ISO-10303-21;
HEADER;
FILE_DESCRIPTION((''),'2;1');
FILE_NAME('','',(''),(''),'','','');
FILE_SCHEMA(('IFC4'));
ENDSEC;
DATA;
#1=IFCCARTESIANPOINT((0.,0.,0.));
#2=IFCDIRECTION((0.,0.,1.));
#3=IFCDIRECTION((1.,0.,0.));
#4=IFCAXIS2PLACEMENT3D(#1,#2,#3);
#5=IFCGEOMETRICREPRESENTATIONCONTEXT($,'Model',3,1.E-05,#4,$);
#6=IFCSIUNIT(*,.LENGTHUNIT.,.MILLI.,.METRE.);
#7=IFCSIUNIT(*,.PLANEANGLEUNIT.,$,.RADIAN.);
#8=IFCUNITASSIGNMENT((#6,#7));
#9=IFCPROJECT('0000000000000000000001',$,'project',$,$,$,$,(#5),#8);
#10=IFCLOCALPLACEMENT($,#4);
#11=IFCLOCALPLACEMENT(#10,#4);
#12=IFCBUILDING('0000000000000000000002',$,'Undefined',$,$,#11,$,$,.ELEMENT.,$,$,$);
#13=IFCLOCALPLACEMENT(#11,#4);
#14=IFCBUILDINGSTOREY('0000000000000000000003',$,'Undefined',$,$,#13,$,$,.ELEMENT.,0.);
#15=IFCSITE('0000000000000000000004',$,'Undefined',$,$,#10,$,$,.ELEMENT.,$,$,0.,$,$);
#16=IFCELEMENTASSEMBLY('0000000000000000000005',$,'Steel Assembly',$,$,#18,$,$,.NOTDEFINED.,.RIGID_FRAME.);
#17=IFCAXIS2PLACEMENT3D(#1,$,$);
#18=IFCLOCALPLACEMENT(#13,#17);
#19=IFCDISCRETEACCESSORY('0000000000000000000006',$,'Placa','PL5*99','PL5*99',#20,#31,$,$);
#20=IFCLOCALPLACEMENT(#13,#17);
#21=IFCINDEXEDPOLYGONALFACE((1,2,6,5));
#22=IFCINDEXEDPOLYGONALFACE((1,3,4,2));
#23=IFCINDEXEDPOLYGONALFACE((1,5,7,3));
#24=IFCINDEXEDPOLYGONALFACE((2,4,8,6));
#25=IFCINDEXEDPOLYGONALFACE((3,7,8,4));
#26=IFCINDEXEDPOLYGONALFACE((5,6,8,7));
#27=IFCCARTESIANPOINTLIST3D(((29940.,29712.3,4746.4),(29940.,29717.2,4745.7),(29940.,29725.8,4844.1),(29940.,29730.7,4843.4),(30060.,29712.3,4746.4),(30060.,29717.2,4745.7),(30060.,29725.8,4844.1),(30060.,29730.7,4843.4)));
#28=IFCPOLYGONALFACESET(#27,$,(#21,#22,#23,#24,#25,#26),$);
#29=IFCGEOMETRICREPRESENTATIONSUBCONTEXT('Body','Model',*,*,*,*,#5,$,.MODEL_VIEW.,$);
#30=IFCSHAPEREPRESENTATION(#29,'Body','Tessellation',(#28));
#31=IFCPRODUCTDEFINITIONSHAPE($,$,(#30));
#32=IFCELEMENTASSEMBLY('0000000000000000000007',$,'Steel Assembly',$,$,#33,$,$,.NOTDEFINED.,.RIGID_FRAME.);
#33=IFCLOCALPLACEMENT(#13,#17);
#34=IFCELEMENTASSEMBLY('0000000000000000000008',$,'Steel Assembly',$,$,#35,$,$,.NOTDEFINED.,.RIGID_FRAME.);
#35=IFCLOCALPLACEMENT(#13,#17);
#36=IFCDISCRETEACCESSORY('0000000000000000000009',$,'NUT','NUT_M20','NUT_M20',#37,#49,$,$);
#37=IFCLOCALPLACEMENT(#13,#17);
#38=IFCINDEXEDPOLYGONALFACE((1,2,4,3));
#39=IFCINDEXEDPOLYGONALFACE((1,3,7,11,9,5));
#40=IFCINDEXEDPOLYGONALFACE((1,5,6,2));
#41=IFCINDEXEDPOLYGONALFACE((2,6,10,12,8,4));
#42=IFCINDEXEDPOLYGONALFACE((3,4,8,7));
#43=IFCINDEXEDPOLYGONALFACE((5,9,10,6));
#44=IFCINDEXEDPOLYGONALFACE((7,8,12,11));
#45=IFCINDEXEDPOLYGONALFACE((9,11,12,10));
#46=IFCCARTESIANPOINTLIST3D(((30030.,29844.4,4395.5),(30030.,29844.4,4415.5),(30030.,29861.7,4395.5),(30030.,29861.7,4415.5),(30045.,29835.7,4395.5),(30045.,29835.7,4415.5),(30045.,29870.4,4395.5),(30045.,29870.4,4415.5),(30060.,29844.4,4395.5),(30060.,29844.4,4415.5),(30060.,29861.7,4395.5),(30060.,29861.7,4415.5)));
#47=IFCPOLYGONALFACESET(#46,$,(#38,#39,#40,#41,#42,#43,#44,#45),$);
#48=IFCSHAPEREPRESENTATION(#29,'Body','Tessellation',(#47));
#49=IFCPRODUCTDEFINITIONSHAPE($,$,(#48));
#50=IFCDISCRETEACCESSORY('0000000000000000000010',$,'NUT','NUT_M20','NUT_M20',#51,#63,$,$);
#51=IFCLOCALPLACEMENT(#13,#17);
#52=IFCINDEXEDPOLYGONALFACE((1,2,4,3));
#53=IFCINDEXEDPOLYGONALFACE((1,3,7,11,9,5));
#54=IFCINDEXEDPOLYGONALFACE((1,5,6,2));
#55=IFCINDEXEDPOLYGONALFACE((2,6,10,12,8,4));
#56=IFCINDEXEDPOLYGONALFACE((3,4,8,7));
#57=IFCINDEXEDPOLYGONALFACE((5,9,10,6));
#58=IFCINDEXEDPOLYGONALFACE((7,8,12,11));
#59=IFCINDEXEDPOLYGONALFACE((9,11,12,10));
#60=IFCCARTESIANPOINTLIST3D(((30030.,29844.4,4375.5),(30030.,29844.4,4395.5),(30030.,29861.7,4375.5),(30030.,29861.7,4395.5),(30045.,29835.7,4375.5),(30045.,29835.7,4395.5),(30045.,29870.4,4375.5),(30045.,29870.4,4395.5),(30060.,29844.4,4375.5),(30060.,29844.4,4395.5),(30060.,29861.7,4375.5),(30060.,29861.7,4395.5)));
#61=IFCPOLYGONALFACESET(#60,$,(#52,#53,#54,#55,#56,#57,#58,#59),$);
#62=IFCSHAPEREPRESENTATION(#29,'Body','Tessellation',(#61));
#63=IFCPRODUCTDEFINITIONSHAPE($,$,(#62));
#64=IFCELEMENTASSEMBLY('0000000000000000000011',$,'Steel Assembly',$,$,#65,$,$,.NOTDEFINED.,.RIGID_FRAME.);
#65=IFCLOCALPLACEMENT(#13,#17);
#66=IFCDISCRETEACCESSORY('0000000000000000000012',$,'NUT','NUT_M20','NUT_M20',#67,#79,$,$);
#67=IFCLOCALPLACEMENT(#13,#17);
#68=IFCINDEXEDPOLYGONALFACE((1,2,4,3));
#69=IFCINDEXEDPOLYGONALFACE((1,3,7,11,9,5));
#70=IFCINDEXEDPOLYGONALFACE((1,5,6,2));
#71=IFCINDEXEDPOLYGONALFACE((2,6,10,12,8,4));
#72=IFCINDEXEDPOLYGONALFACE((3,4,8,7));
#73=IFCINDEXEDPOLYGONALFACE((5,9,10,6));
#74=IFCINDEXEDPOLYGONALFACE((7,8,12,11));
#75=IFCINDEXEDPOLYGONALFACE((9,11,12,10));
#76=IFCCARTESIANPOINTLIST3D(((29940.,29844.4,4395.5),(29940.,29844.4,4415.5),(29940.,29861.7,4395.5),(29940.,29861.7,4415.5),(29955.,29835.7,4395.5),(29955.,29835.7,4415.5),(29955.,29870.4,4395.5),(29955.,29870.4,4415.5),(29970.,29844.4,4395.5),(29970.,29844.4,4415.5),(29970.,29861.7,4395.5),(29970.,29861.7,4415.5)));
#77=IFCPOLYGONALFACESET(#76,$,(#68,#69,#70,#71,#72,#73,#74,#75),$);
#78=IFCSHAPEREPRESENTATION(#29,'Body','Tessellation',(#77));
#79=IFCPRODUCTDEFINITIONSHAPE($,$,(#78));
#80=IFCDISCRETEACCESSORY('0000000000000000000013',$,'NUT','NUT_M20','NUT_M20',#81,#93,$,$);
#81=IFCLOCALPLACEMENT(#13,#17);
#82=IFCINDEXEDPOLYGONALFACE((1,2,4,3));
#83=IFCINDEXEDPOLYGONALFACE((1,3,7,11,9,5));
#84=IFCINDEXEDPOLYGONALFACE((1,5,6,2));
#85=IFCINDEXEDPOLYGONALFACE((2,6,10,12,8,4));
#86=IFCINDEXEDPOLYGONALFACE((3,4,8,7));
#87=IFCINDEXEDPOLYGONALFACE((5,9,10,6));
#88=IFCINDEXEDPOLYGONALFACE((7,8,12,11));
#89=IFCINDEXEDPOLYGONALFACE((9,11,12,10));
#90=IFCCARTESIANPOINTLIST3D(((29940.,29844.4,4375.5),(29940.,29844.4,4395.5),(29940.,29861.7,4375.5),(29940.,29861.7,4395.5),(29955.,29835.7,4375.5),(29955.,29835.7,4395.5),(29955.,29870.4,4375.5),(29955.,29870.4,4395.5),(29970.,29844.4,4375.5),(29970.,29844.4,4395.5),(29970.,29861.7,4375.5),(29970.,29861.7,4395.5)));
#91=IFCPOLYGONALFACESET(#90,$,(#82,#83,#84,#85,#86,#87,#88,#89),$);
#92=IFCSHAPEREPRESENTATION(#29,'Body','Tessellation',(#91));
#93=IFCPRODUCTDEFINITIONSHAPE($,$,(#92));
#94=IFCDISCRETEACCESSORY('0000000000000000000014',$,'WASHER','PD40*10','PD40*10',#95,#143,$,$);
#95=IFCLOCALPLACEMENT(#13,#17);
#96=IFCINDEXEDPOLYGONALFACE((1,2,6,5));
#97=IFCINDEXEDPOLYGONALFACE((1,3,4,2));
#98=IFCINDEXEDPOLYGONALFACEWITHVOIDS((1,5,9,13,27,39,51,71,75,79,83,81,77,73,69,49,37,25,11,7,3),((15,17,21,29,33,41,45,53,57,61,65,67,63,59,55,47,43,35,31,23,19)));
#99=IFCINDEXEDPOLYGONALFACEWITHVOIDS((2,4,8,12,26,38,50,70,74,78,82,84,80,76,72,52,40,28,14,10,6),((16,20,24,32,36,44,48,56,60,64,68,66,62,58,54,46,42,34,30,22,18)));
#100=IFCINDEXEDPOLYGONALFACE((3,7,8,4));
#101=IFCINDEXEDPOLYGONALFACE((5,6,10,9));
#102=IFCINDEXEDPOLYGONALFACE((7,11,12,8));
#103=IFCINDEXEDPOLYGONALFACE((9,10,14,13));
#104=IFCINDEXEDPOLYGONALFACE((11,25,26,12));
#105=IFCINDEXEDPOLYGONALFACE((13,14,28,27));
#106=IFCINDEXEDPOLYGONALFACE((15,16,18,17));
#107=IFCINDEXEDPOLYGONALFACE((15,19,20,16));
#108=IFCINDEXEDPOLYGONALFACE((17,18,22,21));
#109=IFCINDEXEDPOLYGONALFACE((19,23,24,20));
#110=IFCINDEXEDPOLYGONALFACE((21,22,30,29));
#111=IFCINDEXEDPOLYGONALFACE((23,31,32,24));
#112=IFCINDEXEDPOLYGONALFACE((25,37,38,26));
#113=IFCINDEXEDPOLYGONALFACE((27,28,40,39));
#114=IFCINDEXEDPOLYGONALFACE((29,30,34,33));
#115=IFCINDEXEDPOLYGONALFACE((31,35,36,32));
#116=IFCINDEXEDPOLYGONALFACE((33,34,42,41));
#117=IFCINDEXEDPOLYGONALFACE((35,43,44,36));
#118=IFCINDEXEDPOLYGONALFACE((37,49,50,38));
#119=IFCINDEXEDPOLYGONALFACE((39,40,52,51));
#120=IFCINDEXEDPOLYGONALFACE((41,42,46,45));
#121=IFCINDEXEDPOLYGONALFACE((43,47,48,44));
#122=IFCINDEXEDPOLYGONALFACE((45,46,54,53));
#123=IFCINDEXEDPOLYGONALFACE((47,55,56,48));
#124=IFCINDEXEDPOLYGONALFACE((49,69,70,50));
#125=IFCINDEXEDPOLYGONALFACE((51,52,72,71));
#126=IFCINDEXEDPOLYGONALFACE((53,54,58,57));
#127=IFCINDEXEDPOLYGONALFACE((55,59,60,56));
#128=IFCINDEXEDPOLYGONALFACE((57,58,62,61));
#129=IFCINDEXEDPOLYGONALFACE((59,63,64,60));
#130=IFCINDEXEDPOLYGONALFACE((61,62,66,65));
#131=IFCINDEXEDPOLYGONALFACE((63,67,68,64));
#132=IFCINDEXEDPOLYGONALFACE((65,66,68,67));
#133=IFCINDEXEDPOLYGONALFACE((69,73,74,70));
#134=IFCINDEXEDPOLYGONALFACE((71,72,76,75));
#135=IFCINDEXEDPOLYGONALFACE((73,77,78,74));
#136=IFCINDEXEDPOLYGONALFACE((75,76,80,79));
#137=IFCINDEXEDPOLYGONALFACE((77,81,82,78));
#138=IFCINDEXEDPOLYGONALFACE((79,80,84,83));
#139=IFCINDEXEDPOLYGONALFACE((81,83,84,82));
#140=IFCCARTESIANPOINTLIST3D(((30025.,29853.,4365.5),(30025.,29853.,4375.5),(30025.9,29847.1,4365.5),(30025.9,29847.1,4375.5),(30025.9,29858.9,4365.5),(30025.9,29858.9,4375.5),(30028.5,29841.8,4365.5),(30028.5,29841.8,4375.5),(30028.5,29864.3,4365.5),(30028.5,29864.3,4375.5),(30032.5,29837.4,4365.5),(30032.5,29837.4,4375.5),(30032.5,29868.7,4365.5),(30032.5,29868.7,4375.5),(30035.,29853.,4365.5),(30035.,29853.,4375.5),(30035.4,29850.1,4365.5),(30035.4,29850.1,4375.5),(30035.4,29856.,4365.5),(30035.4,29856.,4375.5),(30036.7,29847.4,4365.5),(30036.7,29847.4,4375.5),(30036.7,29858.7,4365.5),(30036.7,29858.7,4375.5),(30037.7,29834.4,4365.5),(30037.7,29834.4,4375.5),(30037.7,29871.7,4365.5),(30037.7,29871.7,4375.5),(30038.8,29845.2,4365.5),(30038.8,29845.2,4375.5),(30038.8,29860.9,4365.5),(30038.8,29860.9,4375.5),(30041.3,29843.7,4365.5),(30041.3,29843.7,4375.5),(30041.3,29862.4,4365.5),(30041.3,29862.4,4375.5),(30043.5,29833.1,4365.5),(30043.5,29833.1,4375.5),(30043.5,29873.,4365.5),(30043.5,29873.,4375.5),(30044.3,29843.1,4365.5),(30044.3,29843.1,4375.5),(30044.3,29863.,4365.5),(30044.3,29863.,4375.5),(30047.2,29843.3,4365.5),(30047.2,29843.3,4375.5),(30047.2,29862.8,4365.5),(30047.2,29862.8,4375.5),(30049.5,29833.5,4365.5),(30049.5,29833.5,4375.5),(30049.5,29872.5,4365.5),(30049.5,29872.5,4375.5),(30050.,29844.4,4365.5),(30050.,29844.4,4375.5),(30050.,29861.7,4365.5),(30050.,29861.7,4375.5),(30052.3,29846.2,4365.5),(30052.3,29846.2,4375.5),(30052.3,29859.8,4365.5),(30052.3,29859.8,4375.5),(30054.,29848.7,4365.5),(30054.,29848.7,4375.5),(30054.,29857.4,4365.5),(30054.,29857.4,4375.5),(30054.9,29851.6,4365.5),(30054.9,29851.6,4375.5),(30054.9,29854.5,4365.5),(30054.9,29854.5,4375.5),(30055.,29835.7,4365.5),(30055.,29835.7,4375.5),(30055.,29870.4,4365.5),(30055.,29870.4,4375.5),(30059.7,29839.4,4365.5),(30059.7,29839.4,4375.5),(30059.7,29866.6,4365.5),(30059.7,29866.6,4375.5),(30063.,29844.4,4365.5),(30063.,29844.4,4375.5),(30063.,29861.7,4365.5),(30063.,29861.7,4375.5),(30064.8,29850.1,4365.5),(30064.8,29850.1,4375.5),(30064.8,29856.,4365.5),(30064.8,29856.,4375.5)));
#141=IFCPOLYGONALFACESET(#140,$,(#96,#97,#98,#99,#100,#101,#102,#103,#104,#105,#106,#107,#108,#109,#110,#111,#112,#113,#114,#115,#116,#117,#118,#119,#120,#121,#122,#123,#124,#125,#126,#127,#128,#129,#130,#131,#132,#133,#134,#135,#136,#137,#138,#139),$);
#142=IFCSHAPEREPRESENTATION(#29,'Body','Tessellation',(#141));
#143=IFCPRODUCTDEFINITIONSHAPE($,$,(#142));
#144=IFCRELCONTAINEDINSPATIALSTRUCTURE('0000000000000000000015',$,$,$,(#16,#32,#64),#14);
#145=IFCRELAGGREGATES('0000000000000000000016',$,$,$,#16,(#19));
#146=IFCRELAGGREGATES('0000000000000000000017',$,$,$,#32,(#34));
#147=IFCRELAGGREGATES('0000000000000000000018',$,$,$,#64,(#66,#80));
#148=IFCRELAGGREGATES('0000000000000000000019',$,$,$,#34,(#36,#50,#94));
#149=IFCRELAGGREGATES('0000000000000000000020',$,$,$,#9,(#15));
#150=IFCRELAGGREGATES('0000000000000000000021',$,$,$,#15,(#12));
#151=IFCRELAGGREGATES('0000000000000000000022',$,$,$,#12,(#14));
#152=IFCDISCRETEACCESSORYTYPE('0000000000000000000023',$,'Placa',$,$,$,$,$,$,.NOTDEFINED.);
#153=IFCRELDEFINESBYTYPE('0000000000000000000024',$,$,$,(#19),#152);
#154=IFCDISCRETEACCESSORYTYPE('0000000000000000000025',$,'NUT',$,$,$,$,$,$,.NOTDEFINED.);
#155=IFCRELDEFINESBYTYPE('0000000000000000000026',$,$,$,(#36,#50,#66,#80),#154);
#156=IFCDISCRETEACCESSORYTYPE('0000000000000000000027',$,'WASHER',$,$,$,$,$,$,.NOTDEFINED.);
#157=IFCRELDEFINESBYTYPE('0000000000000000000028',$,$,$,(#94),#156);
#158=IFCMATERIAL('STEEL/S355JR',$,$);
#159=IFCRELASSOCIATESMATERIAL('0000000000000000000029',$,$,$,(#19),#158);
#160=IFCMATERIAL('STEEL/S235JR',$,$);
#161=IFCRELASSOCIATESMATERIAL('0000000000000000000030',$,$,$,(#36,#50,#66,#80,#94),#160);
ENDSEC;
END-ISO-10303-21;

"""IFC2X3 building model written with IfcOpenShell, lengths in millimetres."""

from ifc_helpers import new_model, si_unit, frame, origin_with_axes, origin_2d_with_axis, place, context, subcontext, project, spatial, polyline, hollow_circle, outline, extrude, material, type_object, element, aggregate, save


model = new_model("IFC2X3")

# Units and contexts
model_context = context("Model", 3, precision=1e-05, world=origin_with_axes())
body_context = subcontext(model_context, "Body", "Model", "MODEL_VIEW")
ifc_project = project(units=[si_unit("LENGTHUNIT", "METRE", prefix="MILLI"), si_unit("PLANEANGLEUNIT", "RADIAN")], contexts=[model_context])

# Site, building, storey
site_placement = place(None, origin_with_axes())
site = spatial("IfcSite", under=ifc_project, at=site_placement, Name="Undefined", CompositionType="ELEMENT", RefElevation=0.0)
building_placement = place(site_placement, origin_with_axes())
building = spatial("IfcBuilding", under=site, at=building_placement, Name="Undefined", CompositionType="ELEMENT")
storey_placement = place(building_placement, origin_with_axes())
storey = spatial("IfcBuildingStorey", under=building, at=storey_placement, Name="Undefined", CompositionType="ELEMENT", Elevation=0.0)

# Shared definitions
ifc_material_1 = material(Name="STEEL/S355JR")

# Element assembly
assembly_1_placement = place(storey_placement, origin_with_axes())
assembly_1 = element("IfcElementAssembly", 1, at=assembly_1_placement, inside=storey, Name="Steel Assembly", AssemblyPlace="NOTDEFINED", PredefinedType="RIGID_FRAME")

# Shared definitions
ifc_material_2 = material(Name="STEEL/S235JR")

# Discrete accessory
discrete_accessory_type_1 = type_object("IfcDiscreteAccessoryType", Name="Placa")
discrete_accessory_1_placement = place(assembly_1_placement, frame((29940.0, 29714.8, 4746.1), z_axis=(0.0, 0.990592, -0.136849), x_axis=(0.0, 0.136849, 0.990592)))
discrete_accessory_1 = element("IfcDiscreteAccessory", 2, at=discrete_accessory_1_placement, type_object=discrete_accessory_type_1, material=ifc_material_1, Name="Placa", Description="PL5*99", ObjectType="PL5*99", context=body_context, shape_type="SweptSolid", body=[
    extrude(outline(polyline([(0.0, 0.0), (98.6, 0.0), (98.6, 120.0), (0.0, 120.0), (0.0, 0.0)])), frame((0.0, 0.0, -2.5), z_axis=(0.0, 0.0, 1.0), x_axis=(1.0, 0.0, 0.0)), (0.0, 0.0, 1.0), 5.0),
])

aggregate(assembly_1, [discrete_accessory_1])

# Element assemblies, discrete accessories
assembly_2_placement = place(storey_placement, origin_with_axes())
assembly_2 = element("IfcElementAssembly", 3, at=assembly_2_placement, inside=storey, Name="Steel Assembly", AssemblyPlace="NOTDEFINED", PredefinedType="RIGID_FRAME")
assembly_3_placement = place(assembly_2_placement, origin_with_axes())
assembly_3 = element("IfcElementAssembly", 4, at=assembly_3_placement, Name="Steel Assembly", AssemblyPlace="NOTDEFINED", PredefinedType="RIGID_FRAME")
aggregate(assembly_2, [assembly_3])
discrete_accessory_type_2 = type_object("IfcDiscreteAccessoryType", Name="NUT")
discrete_accessory_2_placement = place(assembly_3_placement, frame((30045.0, 29853.0, 4415.5), z_axis=(-1.0, 0.0, 0.0), x_axis=(0.0, 0.0, -1.0)))
discrete_accessory_2 = element("IfcDiscreteAccessory", 5, at=discrete_accessory_2_placement, type_object=discrete_accessory_type_2, material=ifc_material_2, Name="NUT", Description="NUT_M20", ObjectType="NUT_M20", context=body_context, shape_type="SweptSolid", body=[
    extrude(outline(polyline([(8.7, 15.0), (17.3, 0.0), (8.7, -15.0), (-8.7, -15.0), (-17.3, 0.0), (-8.7, 15.0), (8.7, 15.0)])), frame((20.0, 0.0, 0.0), z_axis=(-1.0, 0.0, 0.0), x_axis=(0.0, -1.0, 0.0)), (0.0, 0.0, 1.0), 20.0),
])
discrete_accessory_3_placement = place(assembly_3_placement, frame((30045.0, 29853.0, 4395.5), z_axis=(-1.0, 0.0, 0.0), x_axis=(0.0, 0.0, -1.0)))
discrete_accessory_3 = element("IfcDiscreteAccessory", 6, at=discrete_accessory_3_placement, type_object=discrete_accessory_type_2, material=ifc_material_2, Name="NUT", Description="NUT_M20", ObjectType="NUT_M20", context=body_context, shape_type="SweptSolid", body=[
    extrude(outline(polyline([(8.7, 15.0), (17.3, 0.0), (8.7, -15.0), (-8.7, -15.0), (-17.3, 0.0), (-8.7, 15.0), (8.7, 15.0)])), frame((20.0, 0.0, 0.0), z_axis=(-1.0, 0.0, 0.0), x_axis=(0.0, -1.0, 0.0)), (0.0, 0.0, 1.0), 20.0),
])

# Element assembly, discrete accessories
assembly_4_placement = place(storey_placement, origin_with_axes())
assembly_4 = element("IfcElementAssembly", 7, at=assembly_4_placement, inside=storey, Name="Steel Assembly", AssemblyPlace="NOTDEFINED", PredefinedType="RIGID_FRAME")
discrete_accessory_4_placement = place(assembly_4_placement, frame((29955.0, 29853.0, 4415.5), z_axis=(-1.0, 0.0, 0.0), x_axis=(0.0, 0.0, -1.0)))
discrete_accessory_4 = element("IfcDiscreteAccessory", 8, at=discrete_accessory_4_placement, type_object=discrete_accessory_type_2, material=ifc_material_2, Name="NUT", Description="NUT_M20", ObjectType="NUT_M20", context=body_context, shape_type="SweptSolid", body=[
    extrude(outline(polyline([(8.7, 15.0), (17.3, 0.0), (8.7, -15.0), (-8.7, -15.0), (-17.3, 0.0), (-8.7, 15.0), (8.7, 15.0)])), frame((20.0, 0.0, 0.0), z_axis=(-1.0, 0.0, 0.0), x_axis=(0.0, -1.0, 0.0)), (0.0, 0.0, 1.0), 20.0),
])
discrete_accessory_5_placement = place(assembly_4_placement, frame((29955.0, 29853.0, 4395.5), z_axis=(-1.0, 0.0, 0.0), x_axis=(0.0, 0.0, -1.0)))
discrete_accessory_5 = element("IfcDiscreteAccessory", 9, at=discrete_accessory_5_placement, type_object=discrete_accessory_type_2, material=ifc_material_2, Name="NUT", Description="NUT_M20", ObjectType="NUT_M20", context=body_context, shape_type="SweptSolid", body=[
    extrude(outline(polyline([(8.7, 15.0), (17.3, 0.0), (8.7, -15.0), (-8.7, -15.0), (-17.3, 0.0), (-8.7, 15.0), (8.7, 15.0)])), frame((20.0, 0.0, 0.0), z_axis=(-1.0, 0.0, 0.0), x_axis=(0.0, -1.0, 0.0)), (0.0, 0.0, 1.0), 20.0),
])
aggregate(assembly_4, [discrete_accessory_4, discrete_accessory_5])

# Discrete accessory
discrete_accessory_type_3 = type_object("IfcDiscreteAccessoryType", Name="WASHER")
discrete_accessory_6_placement = place(assembly_3_placement, frame((30045.0, 29853.0, 4375.5), z_axis=(0.0, -1.0, 0.0), x_axis=(0.0, 0.0, -1.0)))
discrete_accessory_6 = element("IfcDiscreteAccessory", 10, at=discrete_accessory_6_placement, type_object=discrete_accessory_type_3, material=ifc_material_2, Name="WASHER", Description="PD40*10", ObjectType="PD40*10", context=body_context, shape_type="SweptSolid", body=[
    extrude(hollow_circle(Radius=20.0, WallThickness=10.0, at=origin_2d_with_axis()), frame((10.0, 0.0, 0.0), z_axis=(-1.0, 0.0, 0.0), x_axis=(0.0, -1.0, 0.0)), (0.0, 0.0, 1.0), 10.0),
])
aggregate(assembly_3, [discrete_accessory_2, discrete_accessory_3, discrete_accessory_6])

save(model, "model.ifc")
